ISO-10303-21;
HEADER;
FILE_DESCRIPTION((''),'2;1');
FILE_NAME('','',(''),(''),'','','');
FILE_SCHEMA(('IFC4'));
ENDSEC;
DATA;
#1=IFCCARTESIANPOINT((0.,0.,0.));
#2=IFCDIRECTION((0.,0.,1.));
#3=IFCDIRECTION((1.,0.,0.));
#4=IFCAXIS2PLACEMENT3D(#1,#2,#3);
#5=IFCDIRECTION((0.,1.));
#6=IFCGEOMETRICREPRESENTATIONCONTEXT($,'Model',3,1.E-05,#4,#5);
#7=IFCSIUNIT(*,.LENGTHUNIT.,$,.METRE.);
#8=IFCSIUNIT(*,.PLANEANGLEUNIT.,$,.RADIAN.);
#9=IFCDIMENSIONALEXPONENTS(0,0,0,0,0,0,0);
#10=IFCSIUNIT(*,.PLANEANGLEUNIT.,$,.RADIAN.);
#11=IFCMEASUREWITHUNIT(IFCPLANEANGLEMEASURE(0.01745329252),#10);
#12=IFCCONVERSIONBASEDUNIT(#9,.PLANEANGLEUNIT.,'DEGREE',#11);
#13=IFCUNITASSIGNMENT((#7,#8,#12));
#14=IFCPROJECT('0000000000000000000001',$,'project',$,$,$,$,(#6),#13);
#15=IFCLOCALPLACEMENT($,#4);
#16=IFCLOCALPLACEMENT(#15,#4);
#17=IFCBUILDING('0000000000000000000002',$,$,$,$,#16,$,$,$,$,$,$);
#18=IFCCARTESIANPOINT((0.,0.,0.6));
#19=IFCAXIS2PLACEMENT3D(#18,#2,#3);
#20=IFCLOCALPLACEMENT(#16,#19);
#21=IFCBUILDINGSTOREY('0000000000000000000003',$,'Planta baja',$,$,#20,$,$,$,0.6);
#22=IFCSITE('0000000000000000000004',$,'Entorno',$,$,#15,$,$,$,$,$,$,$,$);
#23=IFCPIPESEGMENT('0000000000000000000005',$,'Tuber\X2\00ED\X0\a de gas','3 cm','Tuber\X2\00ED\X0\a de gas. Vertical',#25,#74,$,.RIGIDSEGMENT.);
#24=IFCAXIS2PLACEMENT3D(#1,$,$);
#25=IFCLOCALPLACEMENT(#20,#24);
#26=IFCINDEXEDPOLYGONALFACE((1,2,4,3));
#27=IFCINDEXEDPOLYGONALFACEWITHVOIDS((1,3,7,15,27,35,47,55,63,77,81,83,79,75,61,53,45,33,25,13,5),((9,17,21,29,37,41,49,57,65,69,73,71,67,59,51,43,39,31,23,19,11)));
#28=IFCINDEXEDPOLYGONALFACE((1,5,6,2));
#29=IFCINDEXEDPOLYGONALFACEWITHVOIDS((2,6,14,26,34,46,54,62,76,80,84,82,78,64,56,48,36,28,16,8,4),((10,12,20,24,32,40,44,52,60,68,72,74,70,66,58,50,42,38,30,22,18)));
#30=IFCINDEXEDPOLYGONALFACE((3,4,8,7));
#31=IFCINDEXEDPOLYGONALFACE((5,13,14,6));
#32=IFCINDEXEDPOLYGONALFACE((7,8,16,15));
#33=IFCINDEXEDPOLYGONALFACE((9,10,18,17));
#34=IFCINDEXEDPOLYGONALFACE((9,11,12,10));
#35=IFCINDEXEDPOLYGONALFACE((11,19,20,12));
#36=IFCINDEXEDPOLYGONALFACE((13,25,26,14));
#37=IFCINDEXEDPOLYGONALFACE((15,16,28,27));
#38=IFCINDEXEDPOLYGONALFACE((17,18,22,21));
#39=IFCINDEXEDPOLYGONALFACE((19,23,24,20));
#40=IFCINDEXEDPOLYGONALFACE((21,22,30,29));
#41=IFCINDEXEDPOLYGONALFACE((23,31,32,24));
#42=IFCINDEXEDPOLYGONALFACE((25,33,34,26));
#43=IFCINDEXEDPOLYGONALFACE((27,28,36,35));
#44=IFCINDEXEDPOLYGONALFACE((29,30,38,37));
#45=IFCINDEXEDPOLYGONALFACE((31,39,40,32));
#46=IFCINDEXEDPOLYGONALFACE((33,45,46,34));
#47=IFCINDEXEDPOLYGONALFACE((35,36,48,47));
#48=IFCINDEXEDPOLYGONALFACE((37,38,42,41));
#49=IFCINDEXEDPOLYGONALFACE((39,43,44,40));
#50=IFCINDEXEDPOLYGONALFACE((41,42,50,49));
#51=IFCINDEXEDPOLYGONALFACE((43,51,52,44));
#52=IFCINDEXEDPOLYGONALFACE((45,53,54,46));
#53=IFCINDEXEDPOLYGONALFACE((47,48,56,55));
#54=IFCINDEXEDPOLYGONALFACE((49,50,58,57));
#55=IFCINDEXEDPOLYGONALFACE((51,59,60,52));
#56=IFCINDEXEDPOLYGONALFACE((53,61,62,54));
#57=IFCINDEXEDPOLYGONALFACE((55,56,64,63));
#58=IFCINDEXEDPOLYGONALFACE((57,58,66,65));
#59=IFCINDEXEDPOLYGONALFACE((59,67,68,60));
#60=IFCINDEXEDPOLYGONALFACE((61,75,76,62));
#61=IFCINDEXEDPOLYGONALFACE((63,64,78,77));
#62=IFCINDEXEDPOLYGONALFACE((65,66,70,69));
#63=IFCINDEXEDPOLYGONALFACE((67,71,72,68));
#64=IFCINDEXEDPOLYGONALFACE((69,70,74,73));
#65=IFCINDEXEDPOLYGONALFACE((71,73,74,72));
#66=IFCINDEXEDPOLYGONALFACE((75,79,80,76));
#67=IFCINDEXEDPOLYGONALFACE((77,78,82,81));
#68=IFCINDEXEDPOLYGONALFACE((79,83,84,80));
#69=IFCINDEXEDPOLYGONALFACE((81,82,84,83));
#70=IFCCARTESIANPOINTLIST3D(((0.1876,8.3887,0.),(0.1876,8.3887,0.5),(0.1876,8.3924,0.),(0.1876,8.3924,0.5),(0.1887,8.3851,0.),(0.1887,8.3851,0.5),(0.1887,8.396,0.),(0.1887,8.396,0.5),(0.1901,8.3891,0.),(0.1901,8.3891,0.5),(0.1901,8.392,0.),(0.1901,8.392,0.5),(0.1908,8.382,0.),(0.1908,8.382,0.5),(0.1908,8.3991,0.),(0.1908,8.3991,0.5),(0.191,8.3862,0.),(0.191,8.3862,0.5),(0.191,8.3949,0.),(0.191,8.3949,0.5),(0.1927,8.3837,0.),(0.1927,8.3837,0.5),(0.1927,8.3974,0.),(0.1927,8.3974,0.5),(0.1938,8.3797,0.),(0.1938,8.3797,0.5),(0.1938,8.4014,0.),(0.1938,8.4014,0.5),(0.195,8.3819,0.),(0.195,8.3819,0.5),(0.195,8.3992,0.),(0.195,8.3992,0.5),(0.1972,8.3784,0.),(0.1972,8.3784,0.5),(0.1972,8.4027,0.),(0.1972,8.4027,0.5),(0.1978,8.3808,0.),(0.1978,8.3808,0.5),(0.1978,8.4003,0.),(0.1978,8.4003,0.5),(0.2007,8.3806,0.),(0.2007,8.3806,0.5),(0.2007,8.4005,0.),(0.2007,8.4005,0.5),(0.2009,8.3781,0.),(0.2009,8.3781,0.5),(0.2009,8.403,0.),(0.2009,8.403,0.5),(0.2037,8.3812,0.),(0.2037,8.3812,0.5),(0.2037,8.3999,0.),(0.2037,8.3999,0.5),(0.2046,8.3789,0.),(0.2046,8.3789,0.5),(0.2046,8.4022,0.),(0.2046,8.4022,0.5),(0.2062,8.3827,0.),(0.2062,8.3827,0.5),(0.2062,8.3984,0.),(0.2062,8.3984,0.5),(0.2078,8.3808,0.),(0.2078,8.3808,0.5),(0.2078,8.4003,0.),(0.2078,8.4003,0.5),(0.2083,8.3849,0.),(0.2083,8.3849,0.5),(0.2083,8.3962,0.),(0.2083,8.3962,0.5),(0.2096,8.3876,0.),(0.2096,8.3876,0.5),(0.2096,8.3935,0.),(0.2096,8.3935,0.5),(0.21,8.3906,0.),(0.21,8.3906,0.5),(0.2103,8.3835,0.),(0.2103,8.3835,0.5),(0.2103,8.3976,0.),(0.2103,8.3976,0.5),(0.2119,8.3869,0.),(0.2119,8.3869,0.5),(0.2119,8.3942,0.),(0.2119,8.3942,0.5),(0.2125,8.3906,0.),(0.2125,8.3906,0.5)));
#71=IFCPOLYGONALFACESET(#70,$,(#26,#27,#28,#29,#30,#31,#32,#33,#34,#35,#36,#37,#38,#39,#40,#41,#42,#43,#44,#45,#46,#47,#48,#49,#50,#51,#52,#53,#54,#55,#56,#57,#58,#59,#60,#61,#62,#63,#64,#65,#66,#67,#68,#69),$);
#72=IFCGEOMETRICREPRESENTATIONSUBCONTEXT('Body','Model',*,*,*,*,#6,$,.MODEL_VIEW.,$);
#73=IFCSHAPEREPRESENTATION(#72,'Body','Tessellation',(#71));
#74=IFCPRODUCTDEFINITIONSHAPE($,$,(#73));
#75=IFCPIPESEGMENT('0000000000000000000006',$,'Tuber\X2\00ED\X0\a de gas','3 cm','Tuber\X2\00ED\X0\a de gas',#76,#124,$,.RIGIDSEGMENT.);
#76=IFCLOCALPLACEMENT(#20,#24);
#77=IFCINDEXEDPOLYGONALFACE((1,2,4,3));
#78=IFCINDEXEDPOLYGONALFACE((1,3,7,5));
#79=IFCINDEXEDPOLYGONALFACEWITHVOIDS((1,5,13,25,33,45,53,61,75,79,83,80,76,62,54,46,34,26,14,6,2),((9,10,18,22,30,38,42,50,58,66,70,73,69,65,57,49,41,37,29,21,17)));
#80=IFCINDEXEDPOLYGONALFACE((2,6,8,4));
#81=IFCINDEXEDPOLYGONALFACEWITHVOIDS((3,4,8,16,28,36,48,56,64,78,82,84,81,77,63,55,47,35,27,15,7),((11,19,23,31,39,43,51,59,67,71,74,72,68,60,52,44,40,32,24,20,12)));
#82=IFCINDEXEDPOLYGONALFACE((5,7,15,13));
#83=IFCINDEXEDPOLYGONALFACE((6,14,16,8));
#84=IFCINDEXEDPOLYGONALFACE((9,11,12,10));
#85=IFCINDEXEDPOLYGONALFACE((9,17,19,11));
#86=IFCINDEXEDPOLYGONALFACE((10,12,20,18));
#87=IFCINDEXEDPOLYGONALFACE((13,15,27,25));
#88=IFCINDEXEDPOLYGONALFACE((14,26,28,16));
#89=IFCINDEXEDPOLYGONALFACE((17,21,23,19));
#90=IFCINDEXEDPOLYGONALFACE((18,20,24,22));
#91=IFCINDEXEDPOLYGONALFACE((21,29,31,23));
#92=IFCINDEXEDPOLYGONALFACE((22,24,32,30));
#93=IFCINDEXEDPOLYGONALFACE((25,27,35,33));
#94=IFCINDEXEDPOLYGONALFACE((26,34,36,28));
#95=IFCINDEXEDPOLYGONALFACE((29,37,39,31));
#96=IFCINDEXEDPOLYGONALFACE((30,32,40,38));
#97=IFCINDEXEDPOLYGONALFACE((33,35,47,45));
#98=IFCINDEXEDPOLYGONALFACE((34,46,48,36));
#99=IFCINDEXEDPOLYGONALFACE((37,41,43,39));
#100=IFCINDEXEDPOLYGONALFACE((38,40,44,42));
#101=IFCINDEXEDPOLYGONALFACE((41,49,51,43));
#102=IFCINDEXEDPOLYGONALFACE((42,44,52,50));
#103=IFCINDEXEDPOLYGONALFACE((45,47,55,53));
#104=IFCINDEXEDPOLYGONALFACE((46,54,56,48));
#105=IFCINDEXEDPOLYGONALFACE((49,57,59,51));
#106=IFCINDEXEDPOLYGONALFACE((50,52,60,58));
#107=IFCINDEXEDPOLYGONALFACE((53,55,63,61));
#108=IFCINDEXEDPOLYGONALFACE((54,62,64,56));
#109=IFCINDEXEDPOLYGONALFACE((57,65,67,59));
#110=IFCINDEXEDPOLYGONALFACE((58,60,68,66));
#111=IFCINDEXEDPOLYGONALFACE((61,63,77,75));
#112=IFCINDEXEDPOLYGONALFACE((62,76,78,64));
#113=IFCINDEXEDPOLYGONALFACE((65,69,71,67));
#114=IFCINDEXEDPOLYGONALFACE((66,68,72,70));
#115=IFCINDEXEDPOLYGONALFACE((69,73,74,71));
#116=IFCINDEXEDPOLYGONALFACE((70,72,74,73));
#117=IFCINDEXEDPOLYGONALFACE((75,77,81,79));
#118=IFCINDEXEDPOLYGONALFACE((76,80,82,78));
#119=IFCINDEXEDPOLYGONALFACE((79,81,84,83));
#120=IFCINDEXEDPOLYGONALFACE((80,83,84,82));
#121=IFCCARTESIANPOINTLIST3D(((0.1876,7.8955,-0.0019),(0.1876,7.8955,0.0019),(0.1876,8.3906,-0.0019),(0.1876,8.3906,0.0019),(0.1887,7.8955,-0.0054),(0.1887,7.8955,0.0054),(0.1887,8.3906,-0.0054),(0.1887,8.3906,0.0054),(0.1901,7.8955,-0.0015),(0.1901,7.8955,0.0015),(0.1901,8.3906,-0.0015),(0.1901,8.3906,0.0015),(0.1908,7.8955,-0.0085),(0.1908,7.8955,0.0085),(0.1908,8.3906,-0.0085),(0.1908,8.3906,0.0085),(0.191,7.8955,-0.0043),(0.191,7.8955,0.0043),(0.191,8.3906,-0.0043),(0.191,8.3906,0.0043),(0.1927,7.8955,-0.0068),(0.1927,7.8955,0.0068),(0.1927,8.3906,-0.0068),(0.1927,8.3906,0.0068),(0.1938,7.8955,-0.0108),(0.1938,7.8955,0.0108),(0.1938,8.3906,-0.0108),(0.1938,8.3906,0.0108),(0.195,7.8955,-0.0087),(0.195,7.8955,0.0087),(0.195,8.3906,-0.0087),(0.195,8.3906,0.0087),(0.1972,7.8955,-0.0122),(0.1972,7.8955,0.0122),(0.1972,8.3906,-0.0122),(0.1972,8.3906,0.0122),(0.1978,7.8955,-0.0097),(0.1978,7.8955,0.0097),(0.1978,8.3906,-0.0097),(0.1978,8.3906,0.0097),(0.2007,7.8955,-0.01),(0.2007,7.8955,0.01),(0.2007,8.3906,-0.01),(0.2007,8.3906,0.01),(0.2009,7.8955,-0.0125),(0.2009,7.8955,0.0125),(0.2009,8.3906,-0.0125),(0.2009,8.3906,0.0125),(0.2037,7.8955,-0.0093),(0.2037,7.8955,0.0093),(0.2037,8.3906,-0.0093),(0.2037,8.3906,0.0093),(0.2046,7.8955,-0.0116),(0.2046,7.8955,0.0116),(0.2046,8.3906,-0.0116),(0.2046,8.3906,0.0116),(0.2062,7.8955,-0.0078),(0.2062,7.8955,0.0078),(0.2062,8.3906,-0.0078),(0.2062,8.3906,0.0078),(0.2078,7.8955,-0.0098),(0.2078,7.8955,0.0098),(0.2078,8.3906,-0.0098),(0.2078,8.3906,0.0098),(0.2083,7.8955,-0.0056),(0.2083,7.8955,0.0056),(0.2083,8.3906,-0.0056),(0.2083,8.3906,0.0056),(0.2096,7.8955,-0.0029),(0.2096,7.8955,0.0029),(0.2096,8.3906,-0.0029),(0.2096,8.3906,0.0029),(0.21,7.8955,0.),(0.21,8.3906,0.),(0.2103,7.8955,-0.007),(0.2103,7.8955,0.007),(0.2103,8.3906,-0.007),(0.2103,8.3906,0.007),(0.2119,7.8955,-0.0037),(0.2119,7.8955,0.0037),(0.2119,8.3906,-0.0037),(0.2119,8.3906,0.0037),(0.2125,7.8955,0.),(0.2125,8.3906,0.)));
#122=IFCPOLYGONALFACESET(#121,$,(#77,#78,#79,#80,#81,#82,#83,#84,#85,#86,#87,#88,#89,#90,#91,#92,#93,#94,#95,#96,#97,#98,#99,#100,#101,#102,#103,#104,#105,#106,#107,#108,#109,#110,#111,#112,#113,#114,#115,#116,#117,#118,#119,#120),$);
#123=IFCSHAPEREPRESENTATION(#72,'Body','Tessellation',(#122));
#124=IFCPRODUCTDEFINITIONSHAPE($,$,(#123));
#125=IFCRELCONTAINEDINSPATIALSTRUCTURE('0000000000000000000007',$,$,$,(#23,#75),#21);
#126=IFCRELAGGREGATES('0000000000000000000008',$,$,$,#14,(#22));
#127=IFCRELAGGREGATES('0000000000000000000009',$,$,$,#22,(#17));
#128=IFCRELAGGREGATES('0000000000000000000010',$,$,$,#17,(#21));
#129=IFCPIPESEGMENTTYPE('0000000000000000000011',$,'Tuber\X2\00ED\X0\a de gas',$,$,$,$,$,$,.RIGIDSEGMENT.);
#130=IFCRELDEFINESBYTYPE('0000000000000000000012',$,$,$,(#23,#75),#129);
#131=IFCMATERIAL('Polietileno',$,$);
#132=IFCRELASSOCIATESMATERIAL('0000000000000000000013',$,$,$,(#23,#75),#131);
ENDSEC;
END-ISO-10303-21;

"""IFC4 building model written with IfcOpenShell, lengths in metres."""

from ifc_helpers import new_model, entity, si_unit, converted_unit, direction, frame, origin_with_axes, origin_2d_with_axis, place, context, subcontext, project, spatial, hollow_circle, extrude, material, type_object, element, save


model = new_model("IFC4")

# Units and contexts
model_context = context("Model", 3, precision=1e-05, world=origin_with_axes(), true_north=direction((0.0, 1.0)))
body_context = subcontext(model_context, "Body", "Model", "MODEL_VIEW")
ifc_project = project(units=[si_unit("LENGTHUNIT", "METRE"), si_unit("PLANEANGLEUNIT", "RADIAN"), converted_unit("PLANEANGLEUNIT", "DEGREE", entity("IfcPlaneAngleMeasure", 0.01745329252), si_unit("PLANEANGLEUNIT", "RADIAN"), dimensions=[0, 0, 0, 0, 0, 0, 0])], contexts=[model_context])

# Site, building, storey
site_placement = place(None, origin_with_axes())
site = spatial("IfcSite", under=ifc_project, at=site_placement, Name="Entorno")
building_placement = place(site_placement, origin_with_axes())
building = spatial("IfcBuilding", under=site, at=building_placement)
storey_placement = place(building_placement, frame((0.0, 0.0, 0.6), z_axis=(0.0, 0.0, 1.0), x_axis=(1.0, 0.0, 0.0)))
storey = spatial("IfcBuildingStorey", under=building, at=storey_placement, Name="Planta baja", Elevation=0.6)

# Pipe segments
ifc_material_1 = material(Name="Polietileno")
pipe_segment_type_1 = type_object("IfcPipeSegmentType", Name="Tubería de gas", PredefinedType="RIGIDSEGMENT")
pipe_segment_1_placement = place(storey_placement, frame((0.2, 8.3906, 0.0), z_axis=(0.0, 0.0, 1.0), x_axis=(1.0, 0.0, 0.0)))
element("IfcPipeSegment", 1, at=pipe_segment_1_placement, inside=storey, type_object=pipe_segment_type_1, material=ifc_material_1, Name="Tubería de gas", Description="3 cm", ObjectType="Tubería de gas. Vertical", PredefinedType="RIGIDSEGMENT", context=body_context, shape_type="SweptSolid", body=[
    extrude(hollow_circle(Radius=0.0125, WallThickness=0.0025, at=origin_2d_with_axis()), origin_with_axes(), (0.0, 0.0, 1.0), 0.5),
])
pipe_segment_2_placement = place(storey_placement, frame((0.2, 8.3906, 0.0), z_axis=(0.0, -1.0, 0.0), x_axis=(1.0, 0.0, 0.0)))
element("IfcPipeSegment", 2, at=pipe_segment_2_placement, inside=storey, type_object=pipe_segment_type_1, material=ifc_material_1, Name="Tubería de gas", Description="3 cm", ObjectType="Tubería de gas", PredefinedType="RIGIDSEGMENT", context=body_context, shape_type="SweptSolid", body=[
    extrude(hollow_circle(Radius=0.0125, WallThickness=0.0025, at=origin_2d_with_axis()), origin_with_axes(), (0.0, 0.0, 1.0), 0.4951),
])

save(model, "model.ifc")
